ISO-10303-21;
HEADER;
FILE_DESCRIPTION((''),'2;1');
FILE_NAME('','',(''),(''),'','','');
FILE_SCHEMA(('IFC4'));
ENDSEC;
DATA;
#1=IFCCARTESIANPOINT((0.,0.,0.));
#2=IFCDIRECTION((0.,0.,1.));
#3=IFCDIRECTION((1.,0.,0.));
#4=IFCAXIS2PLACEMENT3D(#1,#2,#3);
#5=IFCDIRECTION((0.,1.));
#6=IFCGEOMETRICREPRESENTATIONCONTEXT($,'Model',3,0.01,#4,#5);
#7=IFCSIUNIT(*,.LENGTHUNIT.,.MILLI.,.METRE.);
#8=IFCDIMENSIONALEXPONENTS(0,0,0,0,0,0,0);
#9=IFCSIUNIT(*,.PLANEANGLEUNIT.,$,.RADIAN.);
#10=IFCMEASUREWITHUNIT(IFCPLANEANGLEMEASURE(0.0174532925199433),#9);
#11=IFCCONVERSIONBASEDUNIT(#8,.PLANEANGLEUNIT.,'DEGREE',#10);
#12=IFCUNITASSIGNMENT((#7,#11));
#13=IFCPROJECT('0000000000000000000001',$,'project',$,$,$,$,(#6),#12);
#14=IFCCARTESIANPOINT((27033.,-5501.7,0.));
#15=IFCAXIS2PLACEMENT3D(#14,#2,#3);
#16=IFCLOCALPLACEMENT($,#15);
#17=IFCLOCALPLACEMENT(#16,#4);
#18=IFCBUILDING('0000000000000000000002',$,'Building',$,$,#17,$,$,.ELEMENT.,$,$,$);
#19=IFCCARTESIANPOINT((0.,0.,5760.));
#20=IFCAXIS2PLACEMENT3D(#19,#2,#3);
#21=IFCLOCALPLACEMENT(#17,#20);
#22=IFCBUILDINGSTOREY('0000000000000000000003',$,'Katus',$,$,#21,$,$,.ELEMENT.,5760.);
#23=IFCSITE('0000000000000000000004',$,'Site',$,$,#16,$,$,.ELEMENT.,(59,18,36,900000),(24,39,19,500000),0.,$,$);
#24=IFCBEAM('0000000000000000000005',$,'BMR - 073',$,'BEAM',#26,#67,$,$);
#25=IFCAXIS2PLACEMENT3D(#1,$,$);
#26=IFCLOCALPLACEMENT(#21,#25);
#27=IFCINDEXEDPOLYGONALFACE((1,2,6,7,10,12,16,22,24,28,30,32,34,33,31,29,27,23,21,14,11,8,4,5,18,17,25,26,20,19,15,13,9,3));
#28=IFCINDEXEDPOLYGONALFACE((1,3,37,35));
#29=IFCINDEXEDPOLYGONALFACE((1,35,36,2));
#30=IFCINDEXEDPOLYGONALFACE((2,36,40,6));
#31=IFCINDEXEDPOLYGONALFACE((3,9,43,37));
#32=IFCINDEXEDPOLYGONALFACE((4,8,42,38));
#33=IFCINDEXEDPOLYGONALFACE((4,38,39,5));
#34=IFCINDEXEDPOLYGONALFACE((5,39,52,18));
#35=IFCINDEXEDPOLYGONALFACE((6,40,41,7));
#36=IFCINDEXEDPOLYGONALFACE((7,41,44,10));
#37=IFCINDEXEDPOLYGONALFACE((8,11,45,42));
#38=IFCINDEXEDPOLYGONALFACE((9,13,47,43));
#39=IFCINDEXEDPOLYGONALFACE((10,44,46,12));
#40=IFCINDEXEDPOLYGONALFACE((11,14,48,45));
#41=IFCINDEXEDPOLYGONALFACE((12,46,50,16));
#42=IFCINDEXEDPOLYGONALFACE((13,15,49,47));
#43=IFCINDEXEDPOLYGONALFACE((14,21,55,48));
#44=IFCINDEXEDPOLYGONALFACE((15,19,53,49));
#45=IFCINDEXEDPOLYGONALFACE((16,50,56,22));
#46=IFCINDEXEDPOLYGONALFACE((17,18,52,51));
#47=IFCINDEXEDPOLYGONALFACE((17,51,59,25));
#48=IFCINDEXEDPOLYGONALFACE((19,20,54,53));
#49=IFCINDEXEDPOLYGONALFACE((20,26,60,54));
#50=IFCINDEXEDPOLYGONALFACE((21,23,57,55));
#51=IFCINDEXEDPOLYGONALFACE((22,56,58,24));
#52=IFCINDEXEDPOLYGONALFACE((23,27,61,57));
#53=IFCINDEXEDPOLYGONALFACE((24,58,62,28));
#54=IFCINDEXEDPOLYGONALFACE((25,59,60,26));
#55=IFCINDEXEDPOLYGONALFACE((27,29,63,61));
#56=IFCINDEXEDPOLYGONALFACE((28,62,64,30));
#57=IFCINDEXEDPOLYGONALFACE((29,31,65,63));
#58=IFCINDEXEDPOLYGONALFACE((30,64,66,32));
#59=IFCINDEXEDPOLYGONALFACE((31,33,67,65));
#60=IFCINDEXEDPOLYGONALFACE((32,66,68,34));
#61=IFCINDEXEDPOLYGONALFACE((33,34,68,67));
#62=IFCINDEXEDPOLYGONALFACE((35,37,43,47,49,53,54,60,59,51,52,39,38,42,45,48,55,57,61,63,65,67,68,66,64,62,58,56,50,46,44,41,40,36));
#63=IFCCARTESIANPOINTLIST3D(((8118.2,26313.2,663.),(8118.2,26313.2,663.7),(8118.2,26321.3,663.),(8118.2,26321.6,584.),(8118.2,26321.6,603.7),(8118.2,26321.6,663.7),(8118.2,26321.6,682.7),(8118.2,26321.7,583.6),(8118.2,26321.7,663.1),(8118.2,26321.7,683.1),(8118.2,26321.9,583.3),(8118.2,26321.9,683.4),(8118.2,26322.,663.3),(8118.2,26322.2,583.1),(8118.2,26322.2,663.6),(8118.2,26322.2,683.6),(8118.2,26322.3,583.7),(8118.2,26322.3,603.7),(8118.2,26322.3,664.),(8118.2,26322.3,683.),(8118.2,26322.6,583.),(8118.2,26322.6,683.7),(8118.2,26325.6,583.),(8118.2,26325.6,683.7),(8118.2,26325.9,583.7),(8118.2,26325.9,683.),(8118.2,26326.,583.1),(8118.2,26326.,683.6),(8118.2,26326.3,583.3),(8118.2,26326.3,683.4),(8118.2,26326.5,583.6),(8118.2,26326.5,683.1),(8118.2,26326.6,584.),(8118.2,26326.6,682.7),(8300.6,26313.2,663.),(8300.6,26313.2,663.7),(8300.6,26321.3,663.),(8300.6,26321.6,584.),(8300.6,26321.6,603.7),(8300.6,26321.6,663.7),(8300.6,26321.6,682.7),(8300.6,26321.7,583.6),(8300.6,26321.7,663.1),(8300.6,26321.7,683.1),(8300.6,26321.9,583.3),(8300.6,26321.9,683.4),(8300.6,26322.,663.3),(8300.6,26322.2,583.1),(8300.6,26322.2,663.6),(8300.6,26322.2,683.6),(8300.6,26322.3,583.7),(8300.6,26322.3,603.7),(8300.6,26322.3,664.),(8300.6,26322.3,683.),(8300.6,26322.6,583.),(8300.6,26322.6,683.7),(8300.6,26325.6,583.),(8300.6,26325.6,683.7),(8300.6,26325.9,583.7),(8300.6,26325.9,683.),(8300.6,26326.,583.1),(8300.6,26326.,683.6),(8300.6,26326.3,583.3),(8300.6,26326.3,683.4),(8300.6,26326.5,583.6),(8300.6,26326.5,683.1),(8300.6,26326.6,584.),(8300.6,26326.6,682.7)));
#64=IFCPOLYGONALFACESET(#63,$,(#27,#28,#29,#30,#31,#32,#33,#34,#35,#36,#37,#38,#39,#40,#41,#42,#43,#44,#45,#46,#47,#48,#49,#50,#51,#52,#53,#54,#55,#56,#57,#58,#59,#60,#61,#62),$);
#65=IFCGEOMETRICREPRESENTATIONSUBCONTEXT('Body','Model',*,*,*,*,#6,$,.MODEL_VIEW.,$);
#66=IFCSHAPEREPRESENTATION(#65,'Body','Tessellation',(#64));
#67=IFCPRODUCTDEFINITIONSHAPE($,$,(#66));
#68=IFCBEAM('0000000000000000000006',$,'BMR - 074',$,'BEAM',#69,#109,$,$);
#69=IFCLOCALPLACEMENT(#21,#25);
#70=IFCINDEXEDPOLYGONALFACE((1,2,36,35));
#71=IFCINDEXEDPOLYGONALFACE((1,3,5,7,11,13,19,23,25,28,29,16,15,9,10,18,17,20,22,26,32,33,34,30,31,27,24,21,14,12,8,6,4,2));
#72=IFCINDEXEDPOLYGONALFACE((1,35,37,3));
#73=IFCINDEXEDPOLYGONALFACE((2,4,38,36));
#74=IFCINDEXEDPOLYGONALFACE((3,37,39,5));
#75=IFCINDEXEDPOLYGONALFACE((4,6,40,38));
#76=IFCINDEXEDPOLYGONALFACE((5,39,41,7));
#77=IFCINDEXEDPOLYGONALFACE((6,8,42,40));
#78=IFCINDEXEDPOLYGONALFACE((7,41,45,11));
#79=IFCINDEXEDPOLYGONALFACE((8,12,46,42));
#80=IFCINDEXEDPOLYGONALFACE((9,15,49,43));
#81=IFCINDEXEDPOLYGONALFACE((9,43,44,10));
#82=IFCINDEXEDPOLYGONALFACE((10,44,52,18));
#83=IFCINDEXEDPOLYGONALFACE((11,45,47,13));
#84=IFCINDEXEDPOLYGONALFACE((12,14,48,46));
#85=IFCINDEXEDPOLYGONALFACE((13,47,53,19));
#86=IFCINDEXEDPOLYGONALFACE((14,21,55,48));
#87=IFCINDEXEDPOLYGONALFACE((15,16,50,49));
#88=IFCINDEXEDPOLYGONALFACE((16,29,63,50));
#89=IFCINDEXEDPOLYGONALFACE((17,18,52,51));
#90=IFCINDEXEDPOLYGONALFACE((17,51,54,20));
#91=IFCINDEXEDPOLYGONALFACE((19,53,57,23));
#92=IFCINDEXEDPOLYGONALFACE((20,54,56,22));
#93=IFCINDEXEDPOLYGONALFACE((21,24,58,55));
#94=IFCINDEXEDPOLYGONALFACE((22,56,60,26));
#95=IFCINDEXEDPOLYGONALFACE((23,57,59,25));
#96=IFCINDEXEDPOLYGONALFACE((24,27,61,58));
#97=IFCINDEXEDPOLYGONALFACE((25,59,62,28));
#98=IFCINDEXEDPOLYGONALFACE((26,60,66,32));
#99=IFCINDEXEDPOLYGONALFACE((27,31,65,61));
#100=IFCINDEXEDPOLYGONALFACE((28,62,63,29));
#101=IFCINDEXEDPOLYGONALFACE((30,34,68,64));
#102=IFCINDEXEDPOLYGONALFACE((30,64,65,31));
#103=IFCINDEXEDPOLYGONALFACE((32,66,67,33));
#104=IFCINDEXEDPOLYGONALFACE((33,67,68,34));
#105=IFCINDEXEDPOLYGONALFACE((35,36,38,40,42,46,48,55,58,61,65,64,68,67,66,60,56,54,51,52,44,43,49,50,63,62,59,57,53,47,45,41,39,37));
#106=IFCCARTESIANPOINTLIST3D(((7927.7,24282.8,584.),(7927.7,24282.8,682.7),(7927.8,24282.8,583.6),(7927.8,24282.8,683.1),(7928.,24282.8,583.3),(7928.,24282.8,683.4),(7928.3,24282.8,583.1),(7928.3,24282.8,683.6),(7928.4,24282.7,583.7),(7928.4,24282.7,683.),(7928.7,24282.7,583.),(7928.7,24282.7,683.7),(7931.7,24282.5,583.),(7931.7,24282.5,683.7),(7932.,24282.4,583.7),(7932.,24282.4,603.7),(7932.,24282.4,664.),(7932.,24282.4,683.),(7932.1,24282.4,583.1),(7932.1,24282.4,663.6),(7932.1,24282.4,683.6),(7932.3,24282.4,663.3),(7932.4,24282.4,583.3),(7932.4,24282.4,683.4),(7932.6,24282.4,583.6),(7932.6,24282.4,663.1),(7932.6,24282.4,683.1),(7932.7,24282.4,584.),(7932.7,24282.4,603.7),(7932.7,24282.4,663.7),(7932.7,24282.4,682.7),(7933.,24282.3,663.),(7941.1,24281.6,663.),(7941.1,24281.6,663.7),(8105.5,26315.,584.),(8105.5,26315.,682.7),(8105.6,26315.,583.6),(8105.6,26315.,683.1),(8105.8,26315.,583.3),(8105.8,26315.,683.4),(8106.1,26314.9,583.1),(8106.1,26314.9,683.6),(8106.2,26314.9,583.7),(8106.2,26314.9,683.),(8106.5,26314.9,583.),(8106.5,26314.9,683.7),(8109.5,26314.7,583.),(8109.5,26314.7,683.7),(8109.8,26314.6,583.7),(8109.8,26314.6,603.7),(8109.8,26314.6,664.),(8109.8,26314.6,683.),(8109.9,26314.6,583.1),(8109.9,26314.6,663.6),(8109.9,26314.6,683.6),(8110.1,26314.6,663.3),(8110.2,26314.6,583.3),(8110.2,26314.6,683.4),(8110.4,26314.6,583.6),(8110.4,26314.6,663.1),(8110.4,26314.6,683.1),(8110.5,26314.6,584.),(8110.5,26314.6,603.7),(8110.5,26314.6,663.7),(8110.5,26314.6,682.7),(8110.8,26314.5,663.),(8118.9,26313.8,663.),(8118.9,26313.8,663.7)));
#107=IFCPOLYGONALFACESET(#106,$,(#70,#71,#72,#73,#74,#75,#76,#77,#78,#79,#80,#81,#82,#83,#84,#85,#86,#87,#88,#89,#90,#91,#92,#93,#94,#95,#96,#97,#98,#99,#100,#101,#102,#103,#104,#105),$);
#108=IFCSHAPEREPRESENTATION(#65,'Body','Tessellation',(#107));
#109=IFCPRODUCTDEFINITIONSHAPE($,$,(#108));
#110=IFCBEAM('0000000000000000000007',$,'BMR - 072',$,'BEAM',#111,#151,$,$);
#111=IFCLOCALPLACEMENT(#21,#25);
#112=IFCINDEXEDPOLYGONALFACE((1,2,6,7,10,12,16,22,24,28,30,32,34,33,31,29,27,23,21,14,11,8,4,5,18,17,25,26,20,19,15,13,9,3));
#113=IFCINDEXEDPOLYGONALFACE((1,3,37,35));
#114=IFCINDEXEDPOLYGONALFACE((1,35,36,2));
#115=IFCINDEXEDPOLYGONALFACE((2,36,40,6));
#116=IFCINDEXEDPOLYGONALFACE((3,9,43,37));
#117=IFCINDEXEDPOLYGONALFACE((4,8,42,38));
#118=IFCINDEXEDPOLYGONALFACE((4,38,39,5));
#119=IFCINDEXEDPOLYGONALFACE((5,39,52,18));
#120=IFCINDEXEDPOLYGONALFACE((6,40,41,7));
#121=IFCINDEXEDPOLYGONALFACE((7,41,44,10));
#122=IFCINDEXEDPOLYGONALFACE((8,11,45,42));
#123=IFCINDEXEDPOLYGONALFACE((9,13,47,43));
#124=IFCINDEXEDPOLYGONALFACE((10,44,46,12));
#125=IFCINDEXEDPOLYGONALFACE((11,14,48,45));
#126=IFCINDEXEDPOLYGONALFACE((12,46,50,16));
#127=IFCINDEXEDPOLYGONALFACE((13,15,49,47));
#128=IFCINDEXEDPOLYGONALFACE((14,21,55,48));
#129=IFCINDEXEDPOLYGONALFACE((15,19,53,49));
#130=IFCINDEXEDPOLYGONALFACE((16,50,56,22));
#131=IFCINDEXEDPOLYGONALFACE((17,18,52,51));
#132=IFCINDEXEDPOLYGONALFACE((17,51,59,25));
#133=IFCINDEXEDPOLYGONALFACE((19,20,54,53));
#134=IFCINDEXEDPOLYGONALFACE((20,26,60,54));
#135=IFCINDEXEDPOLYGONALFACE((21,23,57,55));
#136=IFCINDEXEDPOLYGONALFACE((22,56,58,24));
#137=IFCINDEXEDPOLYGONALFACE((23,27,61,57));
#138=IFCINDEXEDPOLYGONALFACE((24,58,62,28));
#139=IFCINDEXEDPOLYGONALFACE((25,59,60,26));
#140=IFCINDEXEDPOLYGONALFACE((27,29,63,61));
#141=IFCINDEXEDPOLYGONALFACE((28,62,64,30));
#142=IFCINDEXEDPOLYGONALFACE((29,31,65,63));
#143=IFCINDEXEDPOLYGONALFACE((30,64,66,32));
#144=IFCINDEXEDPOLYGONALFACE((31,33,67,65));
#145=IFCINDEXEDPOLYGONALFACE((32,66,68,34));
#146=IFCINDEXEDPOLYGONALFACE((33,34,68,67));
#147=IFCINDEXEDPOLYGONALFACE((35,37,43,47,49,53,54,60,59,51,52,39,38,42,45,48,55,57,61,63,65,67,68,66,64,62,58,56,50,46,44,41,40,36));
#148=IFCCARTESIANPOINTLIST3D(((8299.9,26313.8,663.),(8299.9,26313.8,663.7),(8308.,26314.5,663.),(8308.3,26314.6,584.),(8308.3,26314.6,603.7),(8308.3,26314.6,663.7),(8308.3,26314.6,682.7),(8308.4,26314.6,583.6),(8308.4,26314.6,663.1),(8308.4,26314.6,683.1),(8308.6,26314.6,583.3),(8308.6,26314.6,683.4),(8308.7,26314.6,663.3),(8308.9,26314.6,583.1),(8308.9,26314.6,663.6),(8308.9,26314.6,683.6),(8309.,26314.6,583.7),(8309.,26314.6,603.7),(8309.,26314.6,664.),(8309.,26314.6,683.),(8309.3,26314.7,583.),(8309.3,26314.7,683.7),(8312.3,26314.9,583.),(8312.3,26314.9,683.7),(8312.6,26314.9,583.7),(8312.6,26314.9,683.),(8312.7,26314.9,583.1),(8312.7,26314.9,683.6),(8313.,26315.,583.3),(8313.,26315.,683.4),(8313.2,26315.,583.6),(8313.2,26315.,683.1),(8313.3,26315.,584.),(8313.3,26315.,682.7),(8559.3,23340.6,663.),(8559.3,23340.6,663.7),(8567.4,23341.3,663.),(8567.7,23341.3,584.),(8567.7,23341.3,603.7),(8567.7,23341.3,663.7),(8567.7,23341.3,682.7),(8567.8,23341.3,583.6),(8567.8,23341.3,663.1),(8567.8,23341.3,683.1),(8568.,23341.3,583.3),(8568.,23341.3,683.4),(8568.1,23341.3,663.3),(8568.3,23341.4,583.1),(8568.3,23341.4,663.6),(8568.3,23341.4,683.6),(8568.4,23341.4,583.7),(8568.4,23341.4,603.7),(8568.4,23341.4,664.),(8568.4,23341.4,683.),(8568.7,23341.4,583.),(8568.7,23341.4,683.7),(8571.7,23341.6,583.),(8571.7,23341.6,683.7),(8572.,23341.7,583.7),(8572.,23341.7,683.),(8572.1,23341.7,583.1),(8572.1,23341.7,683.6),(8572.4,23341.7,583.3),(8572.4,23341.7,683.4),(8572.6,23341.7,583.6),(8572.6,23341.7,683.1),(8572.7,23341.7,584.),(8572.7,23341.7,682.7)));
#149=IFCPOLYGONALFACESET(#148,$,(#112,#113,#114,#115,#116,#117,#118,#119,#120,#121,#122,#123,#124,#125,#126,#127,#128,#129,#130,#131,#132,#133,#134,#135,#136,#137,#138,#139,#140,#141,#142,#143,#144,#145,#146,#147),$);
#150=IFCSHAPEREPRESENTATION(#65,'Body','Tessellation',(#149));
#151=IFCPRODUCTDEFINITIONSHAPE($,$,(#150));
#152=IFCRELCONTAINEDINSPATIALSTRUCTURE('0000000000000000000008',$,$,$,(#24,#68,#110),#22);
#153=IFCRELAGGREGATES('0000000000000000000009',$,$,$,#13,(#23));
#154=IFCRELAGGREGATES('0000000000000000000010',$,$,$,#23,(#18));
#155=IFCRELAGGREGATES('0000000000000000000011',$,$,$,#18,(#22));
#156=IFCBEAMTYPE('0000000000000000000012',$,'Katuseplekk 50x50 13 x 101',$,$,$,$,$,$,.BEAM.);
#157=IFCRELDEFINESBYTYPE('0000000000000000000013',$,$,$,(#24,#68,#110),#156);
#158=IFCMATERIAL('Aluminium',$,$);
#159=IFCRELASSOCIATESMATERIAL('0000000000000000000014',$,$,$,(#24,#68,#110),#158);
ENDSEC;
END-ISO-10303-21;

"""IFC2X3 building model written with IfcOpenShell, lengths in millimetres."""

from ifc_helpers import new_model, entity, si_unit, converted_unit, point, direction, frame, frame_2d, origin_with_axes, place, context, subcontext, project, spatial, polyline, circle_curve, parameter, trimmed, segment, composite_curve, outline, extrude, material, type_object, element, save


model = new_model("IFC2X3")

# Units and contexts
model_context = context("Model", 3, precision=0.01, world=origin_with_axes(), true_north=direction((0.0, 1.0)))
body_context = subcontext(model_context, "Body", "Model", "MODEL_VIEW")
ifc_project = project(units=[si_unit("LENGTHUNIT", "METRE", prefix="MILLI"), converted_unit("PLANEANGLEUNIT", "DEGREE", entity("IfcPlaneAngleMeasure", 0.0174532925199433), si_unit("PLANEANGLEUNIT", "RADIAN"), dimensions=[0, 0, 0, 0, 0, 0, 0])], contexts=[model_context])

# Site, building, storey
site_placement = place(None, frame((27033.0, -5501.7, 0.0), z_axis=(0.0, 0.0, 1.0), x_axis=(1.0, 0.0, 0.0)))
site = spatial("IfcSite", under=ifc_project, at=site_placement, Name="Site", CompositionType="ELEMENT", RefLatitude=(59, 18, 36, 900000), RefLongitude=(24, 39, 19, 500000), RefElevation=0.0)
building_placement = place(site_placement, origin_with_axes())
building = spatial("IfcBuilding", under=site, at=building_placement, Name="Building", CompositionType="ELEMENT")
storey_placement = place(building_placement, frame((0.0, 0.0, 5760.0), z_axis=(0.0, 0.0, 1.0), x_axis=(1.0, 0.0, 0.0)))
storey = spatial("IfcBuildingStorey", under=building, at=storey_placement, Name="Katus", CompositionType="ELEMENT", Elevation=5760.0)

# Beams
ifc_material_1 = material(Name="Aluminium")
beam_type = type_object("IfcBeamType", Name="Katuseplekk 50x50 13 x 101", PredefinedType="BEAM")
beam_1_placement = place(storey_placement, frame((8300.6, 26313.9, 663.0), z_axis=(0.0, 0.0, 1.0), x_axis=(0.0, 1.0, 0.0)))
element("IfcBeam", 1, at=beam_1_placement, inside=storey, type_object=beam_type, material=ifc_material_1, Name="BMR - 073", ObjectType="BEAM", context=body_context, shape_type="SweptSolid", body=[
    extrude(outline(composite_curve([segment(polyline([(-0.7, 0.0), (7.4, 0.0)]), True, "CONTINUOUS"), segment(trimmed(circle_curve(frame_2d((7.4, 1.0), x_axis=(0.0, -1.0)), 1.0), [point((7.4, 0.0)), parameter(0.0)], [point((8.4, 1.0)), parameter(90.0)], True, "CARTESIAN"), True, "CONTINUOUS"), segment(polyline([(8.4, 1.0), (8.4, 20.0), (12.0, 20.0), (12.0, -79.3), (8.4, -79.3), (8.4, -59.3), (7.7, -59.3), (7.7, -79.0)]), True, "CONTINUOUS"), segment(trimmed(circle_curve(frame_2d((8.7, -79.0), x_axis=(-1.0, 0.0)), 1.0), [point((7.7, -79.0)), parameter(0.0)], [point((8.7, -80.0)), parameter(90.0)], True, "CARTESIAN"), True, "CONTINUOUS"), segment(polyline([(8.7, -80.0), (11.7, -80.0)]), True, "CONTINUOUS"), segment(trimmed(circle_curve(frame_2d((11.7, -79.0), x_axis=(0.0, -1.0)), 1.0), [point((11.7, -80.0)), parameter(0.0)], [point((12.7, -79.0)), parameter(90.0)], True, "CARTESIAN"), True, "CONTINUOUS"), segment(polyline([(12.7, -79.0), (12.7, 19.7)]), True, "CONTINUOUS"), segment(trimmed(circle_curve(frame_2d((11.7, 19.7), x_axis=(1.0, 0.0)), 1.0), [point((12.7, 19.7)), parameter(0.0)], [point((11.7, 20.7)), parameter(90.0)], True, "CARTESIAN"), True, "CONTINUOUS"), segment(polyline([(11.7, 20.7), (8.7, 20.7)]), True, "CONTINUOUS"), segment(trimmed(circle_curve(frame_2d((8.7, 19.7), x_axis=(0.0, 1.0)), 1.0), [point((8.7, 20.7)), parameter(0.0)], [point((7.7, 19.7)), parameter(90.0)], True, "CARTESIAN"), True, "CONTINUOUS"), segment(polyline([(7.7, 19.7), (7.7, 0.7), (-0.7, 0.7), (-0.7, 0.0)]), True, "CONTINUOUS")], self_intersect=False)), frame((0.0, 182.4, 0.0), z_axis=(0.0, -1.0, 0.0), x_axis=(1.0, 0.0, 0.0)), (0.0, 0.0, 1.0), 182.4),
])
beam_2_placement = place(storey_placement, frame((8118.2, 26313.9, 663.0), z_axis=(0.0, 0.0, 1.0), x_axis=(-0.996195, 0.087152, 0.0)))
element("IfcBeam", 2, at=beam_2_placement, inside=storey, type_object=beam_type, material=ifc_material_1, Name="BMR - 074", ObjectType="BEAM", context=body_context, shape_type="SweptSolid", body=[
    extrude(outline(composite_curve([segment(polyline([(-0.7, 0.0), (7.4, 0.0)]), True, "CONTINUOUS"), segment(trimmed(circle_curve(frame_2d((7.4, 1.0), x_axis=(0.0, -1.0)), 1.0), [point((7.4, 0.0)), parameter(0.0)], [point((8.4, 1.0)), parameter(90.0)], True, "CARTESIAN"), True, "CONTINUOUS"), segment(polyline([(8.4, 1.0), (8.4, 20.0), (12.0, 20.0), (12.0, -79.3), (8.4, -79.3), (8.4, -59.3), (7.7, -59.3), (7.7, -79.0)]), True, "CONTINUOUS"), segment(trimmed(circle_curve(frame_2d((8.7, -79.0), x_axis=(-1.0, 0.0)), 1.0), [point((7.7, -79.0)), parameter(0.0)], [point((8.7, -80.0)), parameter(90.0)], True, "CARTESIAN"), True, "CONTINUOUS"), segment(polyline([(8.7, -80.0), (11.7, -80.0)]), True, "CONTINUOUS"), segment(trimmed(circle_curve(frame_2d((11.7, -79.0), x_axis=(0.0, -1.0)), 1.0), [point((11.7, -80.0)), parameter(0.0)], [point((12.7, -79.0)), parameter(90.0)], True, "CARTESIAN"), True, "CONTINUOUS"), segment(polyline([(12.7, -79.0), (12.7, 19.7)]), True, "CONTINUOUS"), segment(trimmed(circle_curve(frame_2d((11.7, 19.7), x_axis=(1.0, 0.0)), 1.0), [point((12.7, 19.7)), parameter(0.0)], [point((11.7, 20.7)), parameter(90.0)], True, "CARTESIAN"), True, "CONTINUOUS"), segment(polyline([(11.7, 20.7), (8.7, 20.7)]), True, "CONTINUOUS"), segment(trimmed(circle_curve(frame_2d((8.7, 19.7), x_axis=(0.0, 1.0)), 1.0), [point((8.7, 20.7)), parameter(0.0)], [point((7.7, 19.7)), parameter(90.0)], True, "CARTESIAN"), True, "CONTINUOUS"), segment(polyline([(7.7, 19.7), (7.7, 0.7), (-0.7, 0.7), (-0.7, 0.0)]), True, "CONTINUOUS")], self_intersect=False)), frame((0.0, 2040.0, 0.0), z_axis=(0.0, -1.0, 0.0), x_axis=(1.0, 0.0, 0.0)), (0.0, 0.0, 1.0), 2040.0),
])
beam_3_placement = place(storey_placement, frame((8560.0, 23340.6, 663.0), z_axis=(0.0, 0.0, 1.0), x_axis=(0.996216, 0.08691, 0.0)))
element("IfcBeam", 3, at=beam_3_placement, inside=storey, type_object=beam_type, material=ifc_material_1, Name="BMR - 072", ObjectType="BEAM", context=body_context, shape_type="SweptSolid", body=[
    extrude(outline(composite_curve([segment(polyline([(-0.7, 0.0), (7.4, 0.0)]), True, "CONTINUOUS"), segment(trimmed(circle_curve(frame_2d((7.4, 1.0), x_axis=(0.0, -1.0)), 1.0), [point((7.4, 0.0)), parameter(0.0)], [point((8.4, 1.0)), parameter(90.0)], True, "CARTESIAN"), True, "CONTINUOUS"), segment(polyline([(8.4, 1.0), (8.4, 20.0), (12.0, 20.0), (12.0, -79.3), (8.4, -79.3), (8.4, -59.3), (7.7, -59.3), (7.7, -79.0)]), True, "CONTINUOUS"), segment(trimmed(circle_curve(frame_2d((8.7, -79.0), x_axis=(-1.0, 0.0)), 1.0), [point((7.7, -79.0)), parameter(0.0)], [point((8.7, -80.0)), parameter(90.0)], True, "CARTESIAN"), True, "CONTINUOUS"), segment(polyline([(8.7, -80.0), (11.7, -80.0)]), True, "CONTINUOUS"), segment(trimmed(circle_curve(frame_2d((11.7, -79.0), x_axis=(0.0, -1.0)), 1.0), [point((11.7, -80.0)), parameter(0.0)], [point((12.7, -79.0)), parameter(90.0)], True, "CARTESIAN"), True, "CONTINUOUS"), segment(polyline([(12.7, -79.0), (12.7, 19.7)]), True, "CONTINUOUS"), segment(trimmed(circle_curve(frame_2d((11.7, 19.7), x_axis=(1.0, 0.0)), 1.0), [point((12.7, 19.7)), parameter(0.0)], [point((11.7, 20.7)), parameter(90.0)], True, "CARTESIAN"), True, "CONTINUOUS"), segment(polyline([(11.7, 20.7), (8.7, 20.7)]), True, "CONTINUOUS"), segment(trimmed(circle_curve(frame_2d((8.7, 19.7), x_axis=(0.0, 1.0)), 1.0), [point((8.7, 20.7)), parameter(0.0)], [point((7.7, 19.7)), parameter(90.0)], True, "CARTESIAN"), True, "CONTINUOUS"), segment(polyline([(7.7, 19.7), (7.7, 0.7), (-0.7, 0.7), (-0.7, 0.0)]), True, "CONTINUOUS")], self_intersect=False)), frame((0.0, 2984.6, 0.0), z_axis=(0.0, -1.0, 0.0), x_axis=(1.0, 0.0, 0.0)), (0.0, 0.0, 1.0), 2984.6),
])

save(model, "model.ifc")
